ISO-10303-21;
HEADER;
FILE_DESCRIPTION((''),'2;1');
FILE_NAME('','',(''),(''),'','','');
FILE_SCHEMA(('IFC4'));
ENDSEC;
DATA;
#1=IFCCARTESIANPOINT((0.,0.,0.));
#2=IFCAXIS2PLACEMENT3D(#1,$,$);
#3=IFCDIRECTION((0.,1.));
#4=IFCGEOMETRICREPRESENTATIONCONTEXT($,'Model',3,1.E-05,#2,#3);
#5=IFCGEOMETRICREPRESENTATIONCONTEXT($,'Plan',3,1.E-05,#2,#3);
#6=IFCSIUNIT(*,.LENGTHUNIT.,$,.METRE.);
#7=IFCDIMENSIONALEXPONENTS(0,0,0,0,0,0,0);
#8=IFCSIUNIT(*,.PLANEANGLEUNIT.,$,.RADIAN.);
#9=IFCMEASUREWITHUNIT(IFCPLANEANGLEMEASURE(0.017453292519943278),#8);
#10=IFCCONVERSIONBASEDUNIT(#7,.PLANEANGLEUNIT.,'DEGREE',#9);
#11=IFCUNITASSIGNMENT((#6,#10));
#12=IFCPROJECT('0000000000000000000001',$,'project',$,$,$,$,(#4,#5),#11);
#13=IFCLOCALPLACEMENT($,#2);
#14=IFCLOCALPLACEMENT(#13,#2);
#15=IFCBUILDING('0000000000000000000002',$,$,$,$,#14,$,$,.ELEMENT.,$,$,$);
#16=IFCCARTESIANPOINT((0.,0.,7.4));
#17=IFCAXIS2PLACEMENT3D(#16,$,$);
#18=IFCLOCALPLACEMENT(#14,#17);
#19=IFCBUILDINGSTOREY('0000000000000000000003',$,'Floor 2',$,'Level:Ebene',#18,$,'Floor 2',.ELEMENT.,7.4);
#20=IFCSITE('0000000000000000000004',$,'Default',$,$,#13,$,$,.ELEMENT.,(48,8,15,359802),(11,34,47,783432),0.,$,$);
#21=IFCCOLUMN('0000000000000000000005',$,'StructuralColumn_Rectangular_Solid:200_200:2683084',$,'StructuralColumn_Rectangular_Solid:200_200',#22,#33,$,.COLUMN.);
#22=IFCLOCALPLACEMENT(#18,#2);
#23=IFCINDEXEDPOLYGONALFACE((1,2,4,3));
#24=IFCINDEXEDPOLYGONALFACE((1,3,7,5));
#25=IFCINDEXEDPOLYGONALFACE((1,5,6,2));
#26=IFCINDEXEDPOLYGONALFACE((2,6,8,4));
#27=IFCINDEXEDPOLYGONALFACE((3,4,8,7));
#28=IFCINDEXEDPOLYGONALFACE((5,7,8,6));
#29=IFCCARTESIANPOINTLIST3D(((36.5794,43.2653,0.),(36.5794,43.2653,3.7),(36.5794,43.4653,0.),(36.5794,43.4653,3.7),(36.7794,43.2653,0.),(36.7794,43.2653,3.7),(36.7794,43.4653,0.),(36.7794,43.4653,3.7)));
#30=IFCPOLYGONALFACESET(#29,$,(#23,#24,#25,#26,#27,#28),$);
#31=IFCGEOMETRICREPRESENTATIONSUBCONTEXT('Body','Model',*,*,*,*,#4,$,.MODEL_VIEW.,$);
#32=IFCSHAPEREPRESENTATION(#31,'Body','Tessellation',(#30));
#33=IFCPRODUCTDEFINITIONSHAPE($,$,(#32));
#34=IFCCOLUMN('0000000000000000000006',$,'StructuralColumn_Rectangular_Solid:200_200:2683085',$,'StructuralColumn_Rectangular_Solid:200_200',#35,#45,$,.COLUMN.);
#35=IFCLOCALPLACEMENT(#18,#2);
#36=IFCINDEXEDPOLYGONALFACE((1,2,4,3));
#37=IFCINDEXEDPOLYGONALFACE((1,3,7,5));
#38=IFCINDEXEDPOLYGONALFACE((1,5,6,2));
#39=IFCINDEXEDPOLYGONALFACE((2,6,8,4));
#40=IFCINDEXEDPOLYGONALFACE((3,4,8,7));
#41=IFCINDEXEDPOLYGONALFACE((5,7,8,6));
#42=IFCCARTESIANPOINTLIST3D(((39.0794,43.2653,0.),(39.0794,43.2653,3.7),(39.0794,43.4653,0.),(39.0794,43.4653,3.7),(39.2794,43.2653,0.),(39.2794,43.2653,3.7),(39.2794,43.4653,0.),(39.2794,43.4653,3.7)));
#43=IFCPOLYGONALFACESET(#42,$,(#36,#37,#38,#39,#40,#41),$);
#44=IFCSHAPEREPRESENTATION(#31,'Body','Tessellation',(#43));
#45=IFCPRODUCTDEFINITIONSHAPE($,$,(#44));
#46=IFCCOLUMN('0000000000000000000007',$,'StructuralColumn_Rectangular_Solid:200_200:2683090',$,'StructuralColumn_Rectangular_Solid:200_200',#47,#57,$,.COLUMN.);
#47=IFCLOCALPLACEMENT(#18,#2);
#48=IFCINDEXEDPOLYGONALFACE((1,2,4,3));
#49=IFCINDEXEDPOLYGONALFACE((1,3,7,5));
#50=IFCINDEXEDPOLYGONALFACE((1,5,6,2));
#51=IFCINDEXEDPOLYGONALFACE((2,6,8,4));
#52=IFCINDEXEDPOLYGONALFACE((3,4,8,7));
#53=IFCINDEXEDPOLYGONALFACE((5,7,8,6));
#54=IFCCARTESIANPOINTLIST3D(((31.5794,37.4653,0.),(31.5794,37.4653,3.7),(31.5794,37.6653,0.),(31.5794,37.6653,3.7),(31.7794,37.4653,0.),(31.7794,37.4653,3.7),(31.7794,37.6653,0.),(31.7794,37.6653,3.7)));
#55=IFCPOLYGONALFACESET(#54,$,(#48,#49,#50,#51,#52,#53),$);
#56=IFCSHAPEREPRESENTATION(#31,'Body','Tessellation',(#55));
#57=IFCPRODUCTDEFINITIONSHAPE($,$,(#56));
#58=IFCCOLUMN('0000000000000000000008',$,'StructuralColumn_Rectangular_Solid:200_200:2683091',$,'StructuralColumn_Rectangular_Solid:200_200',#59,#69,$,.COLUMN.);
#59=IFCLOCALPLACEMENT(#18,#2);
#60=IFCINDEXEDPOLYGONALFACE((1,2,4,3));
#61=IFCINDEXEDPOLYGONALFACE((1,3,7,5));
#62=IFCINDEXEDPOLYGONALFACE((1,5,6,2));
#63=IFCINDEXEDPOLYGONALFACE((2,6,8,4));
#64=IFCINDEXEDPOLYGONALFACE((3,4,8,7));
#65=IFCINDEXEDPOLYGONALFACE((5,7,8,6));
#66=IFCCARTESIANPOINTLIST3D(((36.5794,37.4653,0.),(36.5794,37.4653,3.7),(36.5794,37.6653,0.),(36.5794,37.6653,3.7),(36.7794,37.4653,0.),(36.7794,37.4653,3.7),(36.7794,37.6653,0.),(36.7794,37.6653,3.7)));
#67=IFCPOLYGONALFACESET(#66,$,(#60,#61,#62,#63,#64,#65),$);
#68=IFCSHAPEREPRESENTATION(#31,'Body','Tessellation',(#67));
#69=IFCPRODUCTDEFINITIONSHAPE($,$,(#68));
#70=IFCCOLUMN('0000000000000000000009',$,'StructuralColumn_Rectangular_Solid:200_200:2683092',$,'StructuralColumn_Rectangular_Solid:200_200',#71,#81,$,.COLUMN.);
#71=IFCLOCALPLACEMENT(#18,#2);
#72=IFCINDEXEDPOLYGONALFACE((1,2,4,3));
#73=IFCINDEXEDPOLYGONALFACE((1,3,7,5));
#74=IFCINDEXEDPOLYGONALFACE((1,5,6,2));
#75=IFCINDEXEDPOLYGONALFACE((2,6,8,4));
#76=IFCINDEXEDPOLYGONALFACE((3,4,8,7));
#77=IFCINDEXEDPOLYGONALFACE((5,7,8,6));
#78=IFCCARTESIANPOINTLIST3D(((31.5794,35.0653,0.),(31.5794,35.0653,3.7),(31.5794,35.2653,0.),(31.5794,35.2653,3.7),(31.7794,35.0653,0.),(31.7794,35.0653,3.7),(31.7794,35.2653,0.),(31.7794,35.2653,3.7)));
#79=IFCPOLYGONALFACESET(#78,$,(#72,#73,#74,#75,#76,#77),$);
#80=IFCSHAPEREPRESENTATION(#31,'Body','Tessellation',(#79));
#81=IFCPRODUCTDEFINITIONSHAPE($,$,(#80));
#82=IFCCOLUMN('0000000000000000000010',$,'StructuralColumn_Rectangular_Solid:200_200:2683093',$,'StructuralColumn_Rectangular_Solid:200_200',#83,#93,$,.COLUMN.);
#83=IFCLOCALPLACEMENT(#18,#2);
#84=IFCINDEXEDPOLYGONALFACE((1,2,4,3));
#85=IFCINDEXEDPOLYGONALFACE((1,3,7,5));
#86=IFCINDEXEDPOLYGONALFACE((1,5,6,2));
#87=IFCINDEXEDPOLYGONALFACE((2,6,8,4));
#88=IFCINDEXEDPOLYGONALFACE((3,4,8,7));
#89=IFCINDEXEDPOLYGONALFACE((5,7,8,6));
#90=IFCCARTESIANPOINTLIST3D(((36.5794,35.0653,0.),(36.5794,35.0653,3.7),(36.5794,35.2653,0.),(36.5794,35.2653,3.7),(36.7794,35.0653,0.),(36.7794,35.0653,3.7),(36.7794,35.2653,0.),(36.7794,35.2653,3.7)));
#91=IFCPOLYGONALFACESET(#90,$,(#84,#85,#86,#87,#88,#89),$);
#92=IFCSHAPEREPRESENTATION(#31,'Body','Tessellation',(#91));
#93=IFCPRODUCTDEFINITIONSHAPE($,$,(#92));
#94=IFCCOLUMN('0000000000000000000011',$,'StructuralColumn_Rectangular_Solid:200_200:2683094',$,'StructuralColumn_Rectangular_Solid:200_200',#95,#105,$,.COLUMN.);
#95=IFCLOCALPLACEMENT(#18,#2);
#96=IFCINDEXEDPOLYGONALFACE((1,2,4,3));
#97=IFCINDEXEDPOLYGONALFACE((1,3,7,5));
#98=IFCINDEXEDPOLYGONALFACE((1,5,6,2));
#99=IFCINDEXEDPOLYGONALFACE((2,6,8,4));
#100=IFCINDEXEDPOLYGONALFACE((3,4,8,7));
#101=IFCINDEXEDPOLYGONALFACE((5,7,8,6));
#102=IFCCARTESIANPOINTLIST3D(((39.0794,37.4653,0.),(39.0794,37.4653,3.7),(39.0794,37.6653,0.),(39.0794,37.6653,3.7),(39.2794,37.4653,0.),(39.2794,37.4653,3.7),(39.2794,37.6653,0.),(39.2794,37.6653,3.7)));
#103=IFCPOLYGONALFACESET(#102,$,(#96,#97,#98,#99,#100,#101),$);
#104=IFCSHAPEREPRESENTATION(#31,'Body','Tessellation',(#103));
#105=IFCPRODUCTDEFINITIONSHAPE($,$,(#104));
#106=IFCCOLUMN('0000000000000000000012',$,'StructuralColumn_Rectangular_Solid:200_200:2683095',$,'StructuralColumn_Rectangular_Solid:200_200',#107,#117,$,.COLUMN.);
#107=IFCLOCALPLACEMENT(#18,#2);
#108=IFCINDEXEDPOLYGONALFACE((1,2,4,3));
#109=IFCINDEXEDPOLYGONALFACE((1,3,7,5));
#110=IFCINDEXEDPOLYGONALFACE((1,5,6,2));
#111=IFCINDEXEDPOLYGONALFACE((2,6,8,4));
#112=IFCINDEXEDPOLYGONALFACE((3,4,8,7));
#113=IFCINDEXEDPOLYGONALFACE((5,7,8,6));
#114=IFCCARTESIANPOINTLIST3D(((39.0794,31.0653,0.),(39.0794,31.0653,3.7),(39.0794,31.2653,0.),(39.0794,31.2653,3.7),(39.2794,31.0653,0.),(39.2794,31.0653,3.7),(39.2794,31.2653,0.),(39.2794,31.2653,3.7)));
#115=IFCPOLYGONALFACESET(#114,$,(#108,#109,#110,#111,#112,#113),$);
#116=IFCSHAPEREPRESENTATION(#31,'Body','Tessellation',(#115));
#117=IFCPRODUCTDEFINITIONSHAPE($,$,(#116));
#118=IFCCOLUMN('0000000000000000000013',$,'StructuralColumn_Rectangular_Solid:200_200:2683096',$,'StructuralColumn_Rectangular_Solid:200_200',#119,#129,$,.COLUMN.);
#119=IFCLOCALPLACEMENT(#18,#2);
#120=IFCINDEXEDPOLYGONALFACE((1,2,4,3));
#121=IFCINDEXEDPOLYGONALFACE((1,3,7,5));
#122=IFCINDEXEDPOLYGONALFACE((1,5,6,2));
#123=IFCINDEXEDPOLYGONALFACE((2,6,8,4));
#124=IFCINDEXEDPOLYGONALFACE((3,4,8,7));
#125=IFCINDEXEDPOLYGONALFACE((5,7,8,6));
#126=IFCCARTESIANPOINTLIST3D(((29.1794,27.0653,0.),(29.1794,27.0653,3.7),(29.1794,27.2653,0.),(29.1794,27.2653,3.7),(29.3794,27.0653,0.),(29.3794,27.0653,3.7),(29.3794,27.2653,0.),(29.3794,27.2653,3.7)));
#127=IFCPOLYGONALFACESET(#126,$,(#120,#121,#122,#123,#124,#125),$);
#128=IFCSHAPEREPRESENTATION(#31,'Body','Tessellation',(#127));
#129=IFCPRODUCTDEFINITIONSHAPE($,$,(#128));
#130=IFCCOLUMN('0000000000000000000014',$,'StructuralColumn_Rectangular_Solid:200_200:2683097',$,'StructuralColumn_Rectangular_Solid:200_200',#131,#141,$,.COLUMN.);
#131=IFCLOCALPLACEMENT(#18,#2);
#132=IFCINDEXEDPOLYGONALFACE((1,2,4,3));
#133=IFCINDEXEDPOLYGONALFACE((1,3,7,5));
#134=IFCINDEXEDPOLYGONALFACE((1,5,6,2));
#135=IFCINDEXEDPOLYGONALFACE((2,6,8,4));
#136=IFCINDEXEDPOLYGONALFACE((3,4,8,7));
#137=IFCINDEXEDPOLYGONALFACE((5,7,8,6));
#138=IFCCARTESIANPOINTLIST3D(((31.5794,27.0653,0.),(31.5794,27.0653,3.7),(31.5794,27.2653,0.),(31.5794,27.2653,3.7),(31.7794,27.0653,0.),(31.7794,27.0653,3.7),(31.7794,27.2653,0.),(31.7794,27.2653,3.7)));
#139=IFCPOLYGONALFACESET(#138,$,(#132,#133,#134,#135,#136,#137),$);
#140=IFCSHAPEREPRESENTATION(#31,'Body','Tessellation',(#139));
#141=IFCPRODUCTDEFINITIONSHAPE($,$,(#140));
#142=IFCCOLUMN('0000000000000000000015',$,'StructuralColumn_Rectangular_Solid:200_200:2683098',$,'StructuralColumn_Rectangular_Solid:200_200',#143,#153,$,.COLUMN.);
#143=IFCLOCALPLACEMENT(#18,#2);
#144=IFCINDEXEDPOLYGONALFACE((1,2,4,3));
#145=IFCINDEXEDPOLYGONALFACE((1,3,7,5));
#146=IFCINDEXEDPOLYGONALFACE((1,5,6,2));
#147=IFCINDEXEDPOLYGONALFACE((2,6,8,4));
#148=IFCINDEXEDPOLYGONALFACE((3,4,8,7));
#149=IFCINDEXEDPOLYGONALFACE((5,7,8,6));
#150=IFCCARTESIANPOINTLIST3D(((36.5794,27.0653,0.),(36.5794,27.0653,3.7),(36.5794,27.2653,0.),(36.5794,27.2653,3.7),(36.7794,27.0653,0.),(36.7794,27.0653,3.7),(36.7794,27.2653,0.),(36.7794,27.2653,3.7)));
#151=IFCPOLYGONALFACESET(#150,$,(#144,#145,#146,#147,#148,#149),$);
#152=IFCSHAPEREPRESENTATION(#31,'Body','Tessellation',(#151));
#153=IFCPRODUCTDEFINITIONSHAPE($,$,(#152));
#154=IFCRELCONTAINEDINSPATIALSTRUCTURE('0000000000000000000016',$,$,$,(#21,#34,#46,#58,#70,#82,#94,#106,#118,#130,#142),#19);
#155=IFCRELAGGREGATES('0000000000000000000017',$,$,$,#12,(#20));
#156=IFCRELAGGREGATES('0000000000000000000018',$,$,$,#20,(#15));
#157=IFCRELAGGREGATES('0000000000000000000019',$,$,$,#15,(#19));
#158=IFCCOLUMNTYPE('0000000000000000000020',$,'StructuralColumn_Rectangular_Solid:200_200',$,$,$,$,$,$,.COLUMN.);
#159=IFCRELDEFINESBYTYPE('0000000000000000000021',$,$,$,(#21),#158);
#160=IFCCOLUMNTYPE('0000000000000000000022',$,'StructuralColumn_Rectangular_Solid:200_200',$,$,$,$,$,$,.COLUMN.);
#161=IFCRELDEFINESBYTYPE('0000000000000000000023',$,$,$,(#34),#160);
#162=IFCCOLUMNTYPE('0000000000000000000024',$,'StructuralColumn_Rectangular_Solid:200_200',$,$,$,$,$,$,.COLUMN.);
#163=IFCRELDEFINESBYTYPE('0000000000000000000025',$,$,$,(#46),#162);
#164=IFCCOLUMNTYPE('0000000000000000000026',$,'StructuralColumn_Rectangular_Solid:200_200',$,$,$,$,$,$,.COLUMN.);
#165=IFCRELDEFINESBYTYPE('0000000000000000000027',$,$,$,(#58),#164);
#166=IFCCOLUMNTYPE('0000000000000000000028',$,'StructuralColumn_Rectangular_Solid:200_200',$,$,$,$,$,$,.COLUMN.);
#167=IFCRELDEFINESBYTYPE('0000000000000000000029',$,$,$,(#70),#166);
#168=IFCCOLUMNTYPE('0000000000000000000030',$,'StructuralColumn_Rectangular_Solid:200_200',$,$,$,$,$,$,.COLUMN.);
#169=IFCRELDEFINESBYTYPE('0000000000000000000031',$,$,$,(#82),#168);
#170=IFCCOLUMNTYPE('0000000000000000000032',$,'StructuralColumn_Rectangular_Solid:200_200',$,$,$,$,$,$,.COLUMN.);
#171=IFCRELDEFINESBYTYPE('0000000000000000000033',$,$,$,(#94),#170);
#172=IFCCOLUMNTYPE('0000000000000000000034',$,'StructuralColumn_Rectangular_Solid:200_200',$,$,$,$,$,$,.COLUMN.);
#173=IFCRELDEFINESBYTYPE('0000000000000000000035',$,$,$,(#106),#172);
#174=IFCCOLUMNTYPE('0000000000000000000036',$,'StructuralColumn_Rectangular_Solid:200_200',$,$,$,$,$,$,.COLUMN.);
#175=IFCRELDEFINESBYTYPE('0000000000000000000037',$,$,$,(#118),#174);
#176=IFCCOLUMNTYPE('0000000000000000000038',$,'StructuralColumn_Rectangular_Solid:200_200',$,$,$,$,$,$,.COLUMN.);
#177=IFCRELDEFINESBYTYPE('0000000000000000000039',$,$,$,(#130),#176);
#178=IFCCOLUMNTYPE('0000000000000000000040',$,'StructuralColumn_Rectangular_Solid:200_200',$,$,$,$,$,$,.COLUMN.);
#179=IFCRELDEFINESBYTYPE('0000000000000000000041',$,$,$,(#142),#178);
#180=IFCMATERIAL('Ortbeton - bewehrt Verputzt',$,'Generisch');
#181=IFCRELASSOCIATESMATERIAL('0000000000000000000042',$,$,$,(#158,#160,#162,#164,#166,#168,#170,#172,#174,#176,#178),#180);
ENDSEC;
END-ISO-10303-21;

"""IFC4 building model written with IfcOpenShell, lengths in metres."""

from ifc_helpers import new_model, entity, si_unit, converted_unit, direction, frame, frame_2d, origin, origin_2d_with_axis, place, context, subcontext, project, spatial, rectangle, extrude, source, transform, mapped, material, material_profile, profile_set, type_object, type_shapes, element, save


model = new_model("IFC4")

# Units and contexts
model_context = context("Model", 3, precision=1e-05, world=origin(), true_north=direction((0.0, 1.0)))
plan_context = context("Plan", 3, precision=1e-05, world=origin(), true_north=direction((0.0, 1.0)))
body_context = subcontext(model_context, "Body", "Model", "MODEL_VIEW")
ifc_project = project(units=[si_unit("LENGTHUNIT", "METRE"), converted_unit("PLANEANGLEUNIT", "DEGREE", entity("IfcPlaneAngleMeasure", 0.017453292519943278), si_unit("PLANEANGLEUNIT", "RADIAN"), dimensions=[0, 0, 0, 0, 0, 0, 0])], contexts=[model_context, plan_context])

# Site, building, storey
site_placement = place(None, origin())
site = spatial("IfcSite", under=ifc_project, at=site_placement, Name="Default", CompositionType="ELEMENT", RefLatitude=(48, 8, 15, 359802), RefLongitude=(11, 34, 47, 783432), RefElevation=0.0)
building_placement = place(site_placement, origin())
building = spatial("IfcBuilding", under=site, at=building_placement, CompositionType="ELEMENT")
storey_placement = place(building_placement, frame((0.0, 0.0, 7.4)))
storey = spatial("IfcBuildingStorey", under=building, at=storey_placement, Name="Floor 2", ObjectType="Level:Ebene", LongName="Floor 2", CompositionType="ELEMENT", Elevation=7.4)

# Columns
ifc_material_1 = material(Name="Ortbeton - bewehrt Verputzt", Category="Generisch")
ifc_material_profile = material_profile(ifc_material_1, rectangle(XDim=0.2, YDim=0.2, at=frame_2d((0.0, 0.0), x_axis=(1.0, 0.0))), Name="200_200")
ifc_profile_set = profile_set([ifc_material_profile], Name="200_200")
column_type_1 = type_object("IfcColumnType", Name="StructuralColumn_Rectangular_Solid:200_200", PredefinedType="COLUMN", material=ifc_profile_set)
shared_shape_1 = source(origin(), body_context, "Body", "SweptSolid", [
    extrude(rectangle(XDim=0.2, YDim=0.2, at=frame_2d((0.0, 0.0), x_axis=(1.0, 0.0))), frame((36.6794, 43.3653, 7.4), z_axis=(0.0, 0.0, 1.0), x_axis=(-1.0, 0.0, 0.0)), (0.0, 0.0, 1.0), 3.7),
])
type_shapes(column_type_1, [shared_shape_1])
column_1_placement = place(storey_placement, frame((0.0, 0.0, -7.4)))
element("IfcColumn", 1, at=column_1_placement, inside=storey, type_object=column_type_1, Name="StructuralColumn_Rectangular_Solid:200_200:2683084", ObjectType="StructuralColumn_Rectangular_Solid:200_200", PredefinedType="COLUMN", context=body_context, shape_type="MappedRepresentation", body=[
    mapped(shared_shape_1, transform((0.0, 0.0, 0.0), scale=1.0)),
])
column_type_2 = type_object("IfcColumnType", Name="StructuralColumn_Rectangular_Solid:200_200", PredefinedType="COLUMN", material=ifc_profile_set)
shared_shape_2 = source(origin(), body_context, "Body", "SweptSolid", [
    extrude(rectangle(XDim=0.2, YDim=0.2, at=frame_2d((0.0, 0.0), x_axis=(1.0, 0.0))), frame((39.1794, 43.3653, 7.4), z_axis=(0.0, 0.0, 1.0), x_axis=(-1.0, 0.0, 0.0)), (0.0, 0.0, 1.0), 3.7),
])
type_shapes(column_type_2, [shared_shape_2])
column_2_placement = place(storey_placement, frame((0.0, 0.0, -7.4)))
element("IfcColumn", 2, at=column_2_placement, inside=storey, type_object=column_type_2, Name="StructuralColumn_Rectangular_Solid:200_200:2683085", ObjectType="StructuralColumn_Rectangular_Solid:200_200", PredefinedType="COLUMN", context=body_context, shape_type="MappedRepresentation", body=[
    mapped(shared_shape_2, transform((0.0, 0.0, 0.0), scale=1.0)),
])
column_type_3 = type_object("IfcColumnType", Name="StructuralColumn_Rectangular_Solid:200_200", PredefinedType="COLUMN", material=ifc_profile_set)
shared_shape_3 = source(origin(), body_context, "Body", "SweptSolid", [
    extrude(rectangle(XDim=0.2, YDim=0.2, at=frame_2d((0.0, 0.0), x_axis=(1.0, 0.0))), frame((31.6794, 37.5653, 7.4), z_axis=(0.0, 0.0, 1.0), x_axis=(-1.0, 0.0, 0.0)), (0.0, 0.0, 1.0), 3.7),
])
type_shapes(column_type_3, [shared_shape_3])
column_3_placement = place(storey_placement, frame((0.0, 0.0, -7.4)))
element("IfcColumn", 3, at=column_3_placement, inside=storey, type_object=column_type_3, Name="StructuralColumn_Rectangular_Solid:200_200:2683090", ObjectType="StructuralColumn_Rectangular_Solid:200_200", PredefinedType="COLUMN", context=body_context, shape_type="MappedRepresentation", body=[
    mapped(shared_shape_3, transform((0.0, 0.0, 0.0), scale=1.0)),
])
column_type_4 = type_object("IfcColumnType", Name="StructuralColumn_Rectangular_Solid:200_200", PredefinedType="COLUMN", material=ifc_profile_set)
shared_shape_4 = source(origin(), body_context, "Body", "SweptSolid", [
    extrude(rectangle(XDim=0.2, YDim=0.2, at=origin_2d_with_axis()), frame((36.6794, 37.5653, 7.4), z_axis=(0.0, 0.0, 1.0), x_axis=(-1.0, 0.0, 0.0)), (0.0, 0.0, 1.0), 3.7),
])
type_shapes(column_type_4, [shared_shape_4])
column_4_placement = place(storey_placement, frame((0.0, 0.0, -7.4)))
element("IfcColumn", 4, at=column_4_placement, inside=storey, type_object=column_type_4, Name="StructuralColumn_Rectangular_Solid:200_200:2683091", ObjectType="StructuralColumn_Rectangular_Solid:200_200", PredefinedType="COLUMN", context=body_context, shape_type="MappedRepresentation", body=[
    mapped(shared_shape_4, transform((0.0, 0.0, 0.0), scale=1.0)),
])
column_type_5 = type_object("IfcColumnType", Name="StructuralColumn_Rectangular_Solid:200_200", PredefinedType="COLUMN", material=ifc_profile_set)
shared_shape_5 = source(origin(), body_context, "Body", "SweptSolid", [
    extrude(rectangle(XDim=0.2, YDim=0.2, at=origin_2d_with_axis()), frame((31.6794, 35.1653, 7.4), z_axis=(0.0, 0.0, 1.0), x_axis=(-1.0, 0.0, 0.0)), (0.0, 0.0, 1.0), 3.7),
])
type_shapes(column_type_5, [shared_shape_5])
column_5_placement = place(storey_placement, frame((0.0, 0.0, -7.4)))
element("IfcColumn", 5, at=column_5_placement, inside=storey, type_object=column_type_5, Name="StructuralColumn_Rectangular_Solid:200_200:2683092", ObjectType="StructuralColumn_Rectangular_Solid:200_200", PredefinedType="COLUMN", context=body_context, shape_type="MappedRepresentation", body=[
    mapped(shared_shape_5, transform((0.0, 0.0, 0.0), scale=1.0)),
])
column_type_6 = type_object("IfcColumnType", Name="StructuralColumn_Rectangular_Solid:200_200", PredefinedType="COLUMN", material=ifc_profile_set)
shared_shape_6 = source(origin(), body_context, "Body", "SweptSolid", [
    extrude(rectangle(XDim=0.2, YDim=0.2, at=origin_2d_with_axis()), frame((36.6794, 35.1653, 7.4), z_axis=(0.0, 0.0, 1.0), x_axis=(-1.0, 0.0, 0.0)), (0.0, 0.0, 1.0), 3.7),
])
type_shapes(column_type_6, [shared_shape_6])
column_6_placement = place(storey_placement, frame((0.0, 0.0, -7.4)))
element("IfcColumn", 6, at=column_6_placement, inside=storey, type_object=column_type_6, Name="StructuralColumn_Rectangular_Solid:200_200:2683093", ObjectType="StructuralColumn_Rectangular_Solid:200_200", PredefinedType="COLUMN", context=body_context, shape_type="MappedRepresentation", body=[
    mapped(shared_shape_6, transform((0.0, 0.0, 0.0), scale=1.0)),
])
column_type_7 = type_object("IfcColumnType", Name="StructuralColumn_Rectangular_Solid:200_200", PredefinedType="COLUMN", material=ifc_profile_set)
shared_shape_7 = source(origin(), body_context, "Body", "SweptSolid", [
    extrude(rectangle(XDim=0.2, YDim=0.2, at=frame_2d((0.0, 0.0), x_axis=(1.0, 0.0))), frame((39.1794, 37.5653, 7.4), z_axis=(0.0, 0.0, 1.0), x_axis=(-1.0, 0.0, 0.0)), (0.0, 0.0, 1.0), 3.7),
])
type_shapes(column_type_7, [shared_shape_7])
column_7_placement = place(storey_placement, frame((0.0, 0.0, -7.4)))
element("IfcColumn", 7, at=column_7_placement, inside=storey, type_object=column_type_7, Name="StructuralColumn_Rectangular_Solid:200_200:2683094", ObjectType="StructuralColumn_Rectangular_Solid:200_200", PredefinedType="COLUMN", context=body_context, shape_type="MappedRepresentation", body=[
    mapped(shared_shape_7, transform((0.0, 0.0, 0.0), scale=1.0)),
])
column_type_8 = type_object("IfcColumnType", Name="StructuralColumn_Rectangular_Solid:200_200", PredefinedType="COLUMN", material=ifc_profile_set)
shared_shape_8 = source(origin(), body_context, "Body", "SweptSolid", [
    extrude(rectangle(XDim=0.2, YDim=0.2, at=frame_2d((0.0, 0.0), x_axis=(1.0, 0.0))), frame((39.1794, 31.1653, 7.4), z_axis=(0.0, 0.0, 1.0), x_axis=(-1.0, 0.0, 0.0)), (0.0, 0.0, 1.0), 3.7),
])
type_shapes(column_type_8, [shared_shape_8])
column_8_placement = place(storey_placement, frame((0.0, 0.0, -7.4)))
element("IfcColumn", 8, at=column_8_placement, inside=storey, type_object=column_type_8, Name="StructuralColumn_Rectangular_Solid:200_200:2683095", ObjectType="StructuralColumn_Rectangular_Solid:200_200", PredefinedType="COLUMN", context=body_context, shape_type="MappedRepresentation", body=[
    mapped(shared_shape_8, transform((0.0, 0.0, 0.0), scale=1.0)),
])
column_type_9 = type_object("IfcColumnType", Name="StructuralColumn_Rectangular_Solid:200_200", PredefinedType="COLUMN", material=ifc_profile_set)
shared_shape_9 = source(origin(), body_context, "Body", "SweptSolid", [
    extrude(rectangle(XDim=0.2, YDim=0.2, at=frame_2d((0.0, 0.0), x_axis=(1.0, 0.0))), frame((29.2794, 27.1653, 7.4), z_axis=(0.0, 0.0, 1.0), x_axis=(-1.0, 0.0, 0.0)), (0.0, 0.0, 1.0), 3.7),
])
type_shapes(column_type_9, [shared_shape_9])
column_9_placement = place(storey_placement, frame((0.0, 0.0, -7.4)))
element("IfcColumn", 9, at=column_9_placement, inside=storey, type_object=column_type_9, Name="StructuralColumn_Rectangular_Solid:200_200:2683096", ObjectType="StructuralColumn_Rectangular_Solid:200_200", PredefinedType="COLUMN", context=body_context, shape_type="MappedRepresentation", body=[
    mapped(shared_shape_9, transform((0.0, 0.0, 0.0), scale=1.0)),
])
column_type_10 = type_object("IfcColumnType", Name="StructuralColumn_Rectangular_Solid:200_200", PredefinedType="COLUMN", material=ifc_profile_set)
shared_shape_10 = source(origin(), body_context, "Body", "SweptSolid", [
    extrude(rectangle(XDim=0.2, YDim=0.2, at=frame_2d((0.0, 0.0), x_axis=(1.0, 0.0))), frame((31.6794, 27.1653, 7.4), z_axis=(0.0, 0.0, 1.0), x_axis=(-1.0, 0.0, 0.0)), (0.0, 0.0, 1.0), 3.7),
])
type_shapes(column_type_10, [shared_shape_10])
column_10_placement = place(storey_placement, frame((0.0, 0.0, -7.4)))
element("IfcColumn", 10, at=column_10_placement, inside=storey, type_object=column_type_10, Name="StructuralColumn_Rectangular_Solid:200_200:2683097", ObjectType="StructuralColumn_Rectangular_Solid:200_200", PredefinedType="COLUMN", context=body_context, shape_type="MappedRepresentation", body=[
    mapped(shared_shape_10, transform((0.0, 0.0, 0.0), scale=1.0)),
])
column_type_11 = type_object("IfcColumnType", Name="StructuralColumn_Rectangular_Solid:200_200", PredefinedType="COLUMN", material=ifc_profile_set)
shared_shape_11 = source(origin(), body_context, "Body", "SweptSolid", [
    extrude(rectangle(XDim=0.2, YDim=0.2, at=origin_2d_with_axis()), frame((36.6794, 27.1653, 7.4), z_axis=(0.0, 0.0, 1.0), x_axis=(-1.0, 0.0, 0.0)), (0.0, 0.0, 1.0), 3.7),
])
type_shapes(column_type_11, [shared_shape_11])
column_11_placement = place(storey_placement, frame((0.0, 0.0, -7.4)))
element("IfcColumn", 11, at=column_11_placement, inside=storey, type_object=column_type_11, Name="StructuralColumn_Rectangular_Solid:200_200:2683098", ObjectType="StructuralColumn_Rectangular_Solid:200_200", PredefinedType="COLUMN", context=body_context, shape_type="MappedRepresentation", body=[
    mapped(shared_shape_11, transform((0.0, 0.0, 0.0), scale=1.0)),
])

save(model, "model.ifc")
